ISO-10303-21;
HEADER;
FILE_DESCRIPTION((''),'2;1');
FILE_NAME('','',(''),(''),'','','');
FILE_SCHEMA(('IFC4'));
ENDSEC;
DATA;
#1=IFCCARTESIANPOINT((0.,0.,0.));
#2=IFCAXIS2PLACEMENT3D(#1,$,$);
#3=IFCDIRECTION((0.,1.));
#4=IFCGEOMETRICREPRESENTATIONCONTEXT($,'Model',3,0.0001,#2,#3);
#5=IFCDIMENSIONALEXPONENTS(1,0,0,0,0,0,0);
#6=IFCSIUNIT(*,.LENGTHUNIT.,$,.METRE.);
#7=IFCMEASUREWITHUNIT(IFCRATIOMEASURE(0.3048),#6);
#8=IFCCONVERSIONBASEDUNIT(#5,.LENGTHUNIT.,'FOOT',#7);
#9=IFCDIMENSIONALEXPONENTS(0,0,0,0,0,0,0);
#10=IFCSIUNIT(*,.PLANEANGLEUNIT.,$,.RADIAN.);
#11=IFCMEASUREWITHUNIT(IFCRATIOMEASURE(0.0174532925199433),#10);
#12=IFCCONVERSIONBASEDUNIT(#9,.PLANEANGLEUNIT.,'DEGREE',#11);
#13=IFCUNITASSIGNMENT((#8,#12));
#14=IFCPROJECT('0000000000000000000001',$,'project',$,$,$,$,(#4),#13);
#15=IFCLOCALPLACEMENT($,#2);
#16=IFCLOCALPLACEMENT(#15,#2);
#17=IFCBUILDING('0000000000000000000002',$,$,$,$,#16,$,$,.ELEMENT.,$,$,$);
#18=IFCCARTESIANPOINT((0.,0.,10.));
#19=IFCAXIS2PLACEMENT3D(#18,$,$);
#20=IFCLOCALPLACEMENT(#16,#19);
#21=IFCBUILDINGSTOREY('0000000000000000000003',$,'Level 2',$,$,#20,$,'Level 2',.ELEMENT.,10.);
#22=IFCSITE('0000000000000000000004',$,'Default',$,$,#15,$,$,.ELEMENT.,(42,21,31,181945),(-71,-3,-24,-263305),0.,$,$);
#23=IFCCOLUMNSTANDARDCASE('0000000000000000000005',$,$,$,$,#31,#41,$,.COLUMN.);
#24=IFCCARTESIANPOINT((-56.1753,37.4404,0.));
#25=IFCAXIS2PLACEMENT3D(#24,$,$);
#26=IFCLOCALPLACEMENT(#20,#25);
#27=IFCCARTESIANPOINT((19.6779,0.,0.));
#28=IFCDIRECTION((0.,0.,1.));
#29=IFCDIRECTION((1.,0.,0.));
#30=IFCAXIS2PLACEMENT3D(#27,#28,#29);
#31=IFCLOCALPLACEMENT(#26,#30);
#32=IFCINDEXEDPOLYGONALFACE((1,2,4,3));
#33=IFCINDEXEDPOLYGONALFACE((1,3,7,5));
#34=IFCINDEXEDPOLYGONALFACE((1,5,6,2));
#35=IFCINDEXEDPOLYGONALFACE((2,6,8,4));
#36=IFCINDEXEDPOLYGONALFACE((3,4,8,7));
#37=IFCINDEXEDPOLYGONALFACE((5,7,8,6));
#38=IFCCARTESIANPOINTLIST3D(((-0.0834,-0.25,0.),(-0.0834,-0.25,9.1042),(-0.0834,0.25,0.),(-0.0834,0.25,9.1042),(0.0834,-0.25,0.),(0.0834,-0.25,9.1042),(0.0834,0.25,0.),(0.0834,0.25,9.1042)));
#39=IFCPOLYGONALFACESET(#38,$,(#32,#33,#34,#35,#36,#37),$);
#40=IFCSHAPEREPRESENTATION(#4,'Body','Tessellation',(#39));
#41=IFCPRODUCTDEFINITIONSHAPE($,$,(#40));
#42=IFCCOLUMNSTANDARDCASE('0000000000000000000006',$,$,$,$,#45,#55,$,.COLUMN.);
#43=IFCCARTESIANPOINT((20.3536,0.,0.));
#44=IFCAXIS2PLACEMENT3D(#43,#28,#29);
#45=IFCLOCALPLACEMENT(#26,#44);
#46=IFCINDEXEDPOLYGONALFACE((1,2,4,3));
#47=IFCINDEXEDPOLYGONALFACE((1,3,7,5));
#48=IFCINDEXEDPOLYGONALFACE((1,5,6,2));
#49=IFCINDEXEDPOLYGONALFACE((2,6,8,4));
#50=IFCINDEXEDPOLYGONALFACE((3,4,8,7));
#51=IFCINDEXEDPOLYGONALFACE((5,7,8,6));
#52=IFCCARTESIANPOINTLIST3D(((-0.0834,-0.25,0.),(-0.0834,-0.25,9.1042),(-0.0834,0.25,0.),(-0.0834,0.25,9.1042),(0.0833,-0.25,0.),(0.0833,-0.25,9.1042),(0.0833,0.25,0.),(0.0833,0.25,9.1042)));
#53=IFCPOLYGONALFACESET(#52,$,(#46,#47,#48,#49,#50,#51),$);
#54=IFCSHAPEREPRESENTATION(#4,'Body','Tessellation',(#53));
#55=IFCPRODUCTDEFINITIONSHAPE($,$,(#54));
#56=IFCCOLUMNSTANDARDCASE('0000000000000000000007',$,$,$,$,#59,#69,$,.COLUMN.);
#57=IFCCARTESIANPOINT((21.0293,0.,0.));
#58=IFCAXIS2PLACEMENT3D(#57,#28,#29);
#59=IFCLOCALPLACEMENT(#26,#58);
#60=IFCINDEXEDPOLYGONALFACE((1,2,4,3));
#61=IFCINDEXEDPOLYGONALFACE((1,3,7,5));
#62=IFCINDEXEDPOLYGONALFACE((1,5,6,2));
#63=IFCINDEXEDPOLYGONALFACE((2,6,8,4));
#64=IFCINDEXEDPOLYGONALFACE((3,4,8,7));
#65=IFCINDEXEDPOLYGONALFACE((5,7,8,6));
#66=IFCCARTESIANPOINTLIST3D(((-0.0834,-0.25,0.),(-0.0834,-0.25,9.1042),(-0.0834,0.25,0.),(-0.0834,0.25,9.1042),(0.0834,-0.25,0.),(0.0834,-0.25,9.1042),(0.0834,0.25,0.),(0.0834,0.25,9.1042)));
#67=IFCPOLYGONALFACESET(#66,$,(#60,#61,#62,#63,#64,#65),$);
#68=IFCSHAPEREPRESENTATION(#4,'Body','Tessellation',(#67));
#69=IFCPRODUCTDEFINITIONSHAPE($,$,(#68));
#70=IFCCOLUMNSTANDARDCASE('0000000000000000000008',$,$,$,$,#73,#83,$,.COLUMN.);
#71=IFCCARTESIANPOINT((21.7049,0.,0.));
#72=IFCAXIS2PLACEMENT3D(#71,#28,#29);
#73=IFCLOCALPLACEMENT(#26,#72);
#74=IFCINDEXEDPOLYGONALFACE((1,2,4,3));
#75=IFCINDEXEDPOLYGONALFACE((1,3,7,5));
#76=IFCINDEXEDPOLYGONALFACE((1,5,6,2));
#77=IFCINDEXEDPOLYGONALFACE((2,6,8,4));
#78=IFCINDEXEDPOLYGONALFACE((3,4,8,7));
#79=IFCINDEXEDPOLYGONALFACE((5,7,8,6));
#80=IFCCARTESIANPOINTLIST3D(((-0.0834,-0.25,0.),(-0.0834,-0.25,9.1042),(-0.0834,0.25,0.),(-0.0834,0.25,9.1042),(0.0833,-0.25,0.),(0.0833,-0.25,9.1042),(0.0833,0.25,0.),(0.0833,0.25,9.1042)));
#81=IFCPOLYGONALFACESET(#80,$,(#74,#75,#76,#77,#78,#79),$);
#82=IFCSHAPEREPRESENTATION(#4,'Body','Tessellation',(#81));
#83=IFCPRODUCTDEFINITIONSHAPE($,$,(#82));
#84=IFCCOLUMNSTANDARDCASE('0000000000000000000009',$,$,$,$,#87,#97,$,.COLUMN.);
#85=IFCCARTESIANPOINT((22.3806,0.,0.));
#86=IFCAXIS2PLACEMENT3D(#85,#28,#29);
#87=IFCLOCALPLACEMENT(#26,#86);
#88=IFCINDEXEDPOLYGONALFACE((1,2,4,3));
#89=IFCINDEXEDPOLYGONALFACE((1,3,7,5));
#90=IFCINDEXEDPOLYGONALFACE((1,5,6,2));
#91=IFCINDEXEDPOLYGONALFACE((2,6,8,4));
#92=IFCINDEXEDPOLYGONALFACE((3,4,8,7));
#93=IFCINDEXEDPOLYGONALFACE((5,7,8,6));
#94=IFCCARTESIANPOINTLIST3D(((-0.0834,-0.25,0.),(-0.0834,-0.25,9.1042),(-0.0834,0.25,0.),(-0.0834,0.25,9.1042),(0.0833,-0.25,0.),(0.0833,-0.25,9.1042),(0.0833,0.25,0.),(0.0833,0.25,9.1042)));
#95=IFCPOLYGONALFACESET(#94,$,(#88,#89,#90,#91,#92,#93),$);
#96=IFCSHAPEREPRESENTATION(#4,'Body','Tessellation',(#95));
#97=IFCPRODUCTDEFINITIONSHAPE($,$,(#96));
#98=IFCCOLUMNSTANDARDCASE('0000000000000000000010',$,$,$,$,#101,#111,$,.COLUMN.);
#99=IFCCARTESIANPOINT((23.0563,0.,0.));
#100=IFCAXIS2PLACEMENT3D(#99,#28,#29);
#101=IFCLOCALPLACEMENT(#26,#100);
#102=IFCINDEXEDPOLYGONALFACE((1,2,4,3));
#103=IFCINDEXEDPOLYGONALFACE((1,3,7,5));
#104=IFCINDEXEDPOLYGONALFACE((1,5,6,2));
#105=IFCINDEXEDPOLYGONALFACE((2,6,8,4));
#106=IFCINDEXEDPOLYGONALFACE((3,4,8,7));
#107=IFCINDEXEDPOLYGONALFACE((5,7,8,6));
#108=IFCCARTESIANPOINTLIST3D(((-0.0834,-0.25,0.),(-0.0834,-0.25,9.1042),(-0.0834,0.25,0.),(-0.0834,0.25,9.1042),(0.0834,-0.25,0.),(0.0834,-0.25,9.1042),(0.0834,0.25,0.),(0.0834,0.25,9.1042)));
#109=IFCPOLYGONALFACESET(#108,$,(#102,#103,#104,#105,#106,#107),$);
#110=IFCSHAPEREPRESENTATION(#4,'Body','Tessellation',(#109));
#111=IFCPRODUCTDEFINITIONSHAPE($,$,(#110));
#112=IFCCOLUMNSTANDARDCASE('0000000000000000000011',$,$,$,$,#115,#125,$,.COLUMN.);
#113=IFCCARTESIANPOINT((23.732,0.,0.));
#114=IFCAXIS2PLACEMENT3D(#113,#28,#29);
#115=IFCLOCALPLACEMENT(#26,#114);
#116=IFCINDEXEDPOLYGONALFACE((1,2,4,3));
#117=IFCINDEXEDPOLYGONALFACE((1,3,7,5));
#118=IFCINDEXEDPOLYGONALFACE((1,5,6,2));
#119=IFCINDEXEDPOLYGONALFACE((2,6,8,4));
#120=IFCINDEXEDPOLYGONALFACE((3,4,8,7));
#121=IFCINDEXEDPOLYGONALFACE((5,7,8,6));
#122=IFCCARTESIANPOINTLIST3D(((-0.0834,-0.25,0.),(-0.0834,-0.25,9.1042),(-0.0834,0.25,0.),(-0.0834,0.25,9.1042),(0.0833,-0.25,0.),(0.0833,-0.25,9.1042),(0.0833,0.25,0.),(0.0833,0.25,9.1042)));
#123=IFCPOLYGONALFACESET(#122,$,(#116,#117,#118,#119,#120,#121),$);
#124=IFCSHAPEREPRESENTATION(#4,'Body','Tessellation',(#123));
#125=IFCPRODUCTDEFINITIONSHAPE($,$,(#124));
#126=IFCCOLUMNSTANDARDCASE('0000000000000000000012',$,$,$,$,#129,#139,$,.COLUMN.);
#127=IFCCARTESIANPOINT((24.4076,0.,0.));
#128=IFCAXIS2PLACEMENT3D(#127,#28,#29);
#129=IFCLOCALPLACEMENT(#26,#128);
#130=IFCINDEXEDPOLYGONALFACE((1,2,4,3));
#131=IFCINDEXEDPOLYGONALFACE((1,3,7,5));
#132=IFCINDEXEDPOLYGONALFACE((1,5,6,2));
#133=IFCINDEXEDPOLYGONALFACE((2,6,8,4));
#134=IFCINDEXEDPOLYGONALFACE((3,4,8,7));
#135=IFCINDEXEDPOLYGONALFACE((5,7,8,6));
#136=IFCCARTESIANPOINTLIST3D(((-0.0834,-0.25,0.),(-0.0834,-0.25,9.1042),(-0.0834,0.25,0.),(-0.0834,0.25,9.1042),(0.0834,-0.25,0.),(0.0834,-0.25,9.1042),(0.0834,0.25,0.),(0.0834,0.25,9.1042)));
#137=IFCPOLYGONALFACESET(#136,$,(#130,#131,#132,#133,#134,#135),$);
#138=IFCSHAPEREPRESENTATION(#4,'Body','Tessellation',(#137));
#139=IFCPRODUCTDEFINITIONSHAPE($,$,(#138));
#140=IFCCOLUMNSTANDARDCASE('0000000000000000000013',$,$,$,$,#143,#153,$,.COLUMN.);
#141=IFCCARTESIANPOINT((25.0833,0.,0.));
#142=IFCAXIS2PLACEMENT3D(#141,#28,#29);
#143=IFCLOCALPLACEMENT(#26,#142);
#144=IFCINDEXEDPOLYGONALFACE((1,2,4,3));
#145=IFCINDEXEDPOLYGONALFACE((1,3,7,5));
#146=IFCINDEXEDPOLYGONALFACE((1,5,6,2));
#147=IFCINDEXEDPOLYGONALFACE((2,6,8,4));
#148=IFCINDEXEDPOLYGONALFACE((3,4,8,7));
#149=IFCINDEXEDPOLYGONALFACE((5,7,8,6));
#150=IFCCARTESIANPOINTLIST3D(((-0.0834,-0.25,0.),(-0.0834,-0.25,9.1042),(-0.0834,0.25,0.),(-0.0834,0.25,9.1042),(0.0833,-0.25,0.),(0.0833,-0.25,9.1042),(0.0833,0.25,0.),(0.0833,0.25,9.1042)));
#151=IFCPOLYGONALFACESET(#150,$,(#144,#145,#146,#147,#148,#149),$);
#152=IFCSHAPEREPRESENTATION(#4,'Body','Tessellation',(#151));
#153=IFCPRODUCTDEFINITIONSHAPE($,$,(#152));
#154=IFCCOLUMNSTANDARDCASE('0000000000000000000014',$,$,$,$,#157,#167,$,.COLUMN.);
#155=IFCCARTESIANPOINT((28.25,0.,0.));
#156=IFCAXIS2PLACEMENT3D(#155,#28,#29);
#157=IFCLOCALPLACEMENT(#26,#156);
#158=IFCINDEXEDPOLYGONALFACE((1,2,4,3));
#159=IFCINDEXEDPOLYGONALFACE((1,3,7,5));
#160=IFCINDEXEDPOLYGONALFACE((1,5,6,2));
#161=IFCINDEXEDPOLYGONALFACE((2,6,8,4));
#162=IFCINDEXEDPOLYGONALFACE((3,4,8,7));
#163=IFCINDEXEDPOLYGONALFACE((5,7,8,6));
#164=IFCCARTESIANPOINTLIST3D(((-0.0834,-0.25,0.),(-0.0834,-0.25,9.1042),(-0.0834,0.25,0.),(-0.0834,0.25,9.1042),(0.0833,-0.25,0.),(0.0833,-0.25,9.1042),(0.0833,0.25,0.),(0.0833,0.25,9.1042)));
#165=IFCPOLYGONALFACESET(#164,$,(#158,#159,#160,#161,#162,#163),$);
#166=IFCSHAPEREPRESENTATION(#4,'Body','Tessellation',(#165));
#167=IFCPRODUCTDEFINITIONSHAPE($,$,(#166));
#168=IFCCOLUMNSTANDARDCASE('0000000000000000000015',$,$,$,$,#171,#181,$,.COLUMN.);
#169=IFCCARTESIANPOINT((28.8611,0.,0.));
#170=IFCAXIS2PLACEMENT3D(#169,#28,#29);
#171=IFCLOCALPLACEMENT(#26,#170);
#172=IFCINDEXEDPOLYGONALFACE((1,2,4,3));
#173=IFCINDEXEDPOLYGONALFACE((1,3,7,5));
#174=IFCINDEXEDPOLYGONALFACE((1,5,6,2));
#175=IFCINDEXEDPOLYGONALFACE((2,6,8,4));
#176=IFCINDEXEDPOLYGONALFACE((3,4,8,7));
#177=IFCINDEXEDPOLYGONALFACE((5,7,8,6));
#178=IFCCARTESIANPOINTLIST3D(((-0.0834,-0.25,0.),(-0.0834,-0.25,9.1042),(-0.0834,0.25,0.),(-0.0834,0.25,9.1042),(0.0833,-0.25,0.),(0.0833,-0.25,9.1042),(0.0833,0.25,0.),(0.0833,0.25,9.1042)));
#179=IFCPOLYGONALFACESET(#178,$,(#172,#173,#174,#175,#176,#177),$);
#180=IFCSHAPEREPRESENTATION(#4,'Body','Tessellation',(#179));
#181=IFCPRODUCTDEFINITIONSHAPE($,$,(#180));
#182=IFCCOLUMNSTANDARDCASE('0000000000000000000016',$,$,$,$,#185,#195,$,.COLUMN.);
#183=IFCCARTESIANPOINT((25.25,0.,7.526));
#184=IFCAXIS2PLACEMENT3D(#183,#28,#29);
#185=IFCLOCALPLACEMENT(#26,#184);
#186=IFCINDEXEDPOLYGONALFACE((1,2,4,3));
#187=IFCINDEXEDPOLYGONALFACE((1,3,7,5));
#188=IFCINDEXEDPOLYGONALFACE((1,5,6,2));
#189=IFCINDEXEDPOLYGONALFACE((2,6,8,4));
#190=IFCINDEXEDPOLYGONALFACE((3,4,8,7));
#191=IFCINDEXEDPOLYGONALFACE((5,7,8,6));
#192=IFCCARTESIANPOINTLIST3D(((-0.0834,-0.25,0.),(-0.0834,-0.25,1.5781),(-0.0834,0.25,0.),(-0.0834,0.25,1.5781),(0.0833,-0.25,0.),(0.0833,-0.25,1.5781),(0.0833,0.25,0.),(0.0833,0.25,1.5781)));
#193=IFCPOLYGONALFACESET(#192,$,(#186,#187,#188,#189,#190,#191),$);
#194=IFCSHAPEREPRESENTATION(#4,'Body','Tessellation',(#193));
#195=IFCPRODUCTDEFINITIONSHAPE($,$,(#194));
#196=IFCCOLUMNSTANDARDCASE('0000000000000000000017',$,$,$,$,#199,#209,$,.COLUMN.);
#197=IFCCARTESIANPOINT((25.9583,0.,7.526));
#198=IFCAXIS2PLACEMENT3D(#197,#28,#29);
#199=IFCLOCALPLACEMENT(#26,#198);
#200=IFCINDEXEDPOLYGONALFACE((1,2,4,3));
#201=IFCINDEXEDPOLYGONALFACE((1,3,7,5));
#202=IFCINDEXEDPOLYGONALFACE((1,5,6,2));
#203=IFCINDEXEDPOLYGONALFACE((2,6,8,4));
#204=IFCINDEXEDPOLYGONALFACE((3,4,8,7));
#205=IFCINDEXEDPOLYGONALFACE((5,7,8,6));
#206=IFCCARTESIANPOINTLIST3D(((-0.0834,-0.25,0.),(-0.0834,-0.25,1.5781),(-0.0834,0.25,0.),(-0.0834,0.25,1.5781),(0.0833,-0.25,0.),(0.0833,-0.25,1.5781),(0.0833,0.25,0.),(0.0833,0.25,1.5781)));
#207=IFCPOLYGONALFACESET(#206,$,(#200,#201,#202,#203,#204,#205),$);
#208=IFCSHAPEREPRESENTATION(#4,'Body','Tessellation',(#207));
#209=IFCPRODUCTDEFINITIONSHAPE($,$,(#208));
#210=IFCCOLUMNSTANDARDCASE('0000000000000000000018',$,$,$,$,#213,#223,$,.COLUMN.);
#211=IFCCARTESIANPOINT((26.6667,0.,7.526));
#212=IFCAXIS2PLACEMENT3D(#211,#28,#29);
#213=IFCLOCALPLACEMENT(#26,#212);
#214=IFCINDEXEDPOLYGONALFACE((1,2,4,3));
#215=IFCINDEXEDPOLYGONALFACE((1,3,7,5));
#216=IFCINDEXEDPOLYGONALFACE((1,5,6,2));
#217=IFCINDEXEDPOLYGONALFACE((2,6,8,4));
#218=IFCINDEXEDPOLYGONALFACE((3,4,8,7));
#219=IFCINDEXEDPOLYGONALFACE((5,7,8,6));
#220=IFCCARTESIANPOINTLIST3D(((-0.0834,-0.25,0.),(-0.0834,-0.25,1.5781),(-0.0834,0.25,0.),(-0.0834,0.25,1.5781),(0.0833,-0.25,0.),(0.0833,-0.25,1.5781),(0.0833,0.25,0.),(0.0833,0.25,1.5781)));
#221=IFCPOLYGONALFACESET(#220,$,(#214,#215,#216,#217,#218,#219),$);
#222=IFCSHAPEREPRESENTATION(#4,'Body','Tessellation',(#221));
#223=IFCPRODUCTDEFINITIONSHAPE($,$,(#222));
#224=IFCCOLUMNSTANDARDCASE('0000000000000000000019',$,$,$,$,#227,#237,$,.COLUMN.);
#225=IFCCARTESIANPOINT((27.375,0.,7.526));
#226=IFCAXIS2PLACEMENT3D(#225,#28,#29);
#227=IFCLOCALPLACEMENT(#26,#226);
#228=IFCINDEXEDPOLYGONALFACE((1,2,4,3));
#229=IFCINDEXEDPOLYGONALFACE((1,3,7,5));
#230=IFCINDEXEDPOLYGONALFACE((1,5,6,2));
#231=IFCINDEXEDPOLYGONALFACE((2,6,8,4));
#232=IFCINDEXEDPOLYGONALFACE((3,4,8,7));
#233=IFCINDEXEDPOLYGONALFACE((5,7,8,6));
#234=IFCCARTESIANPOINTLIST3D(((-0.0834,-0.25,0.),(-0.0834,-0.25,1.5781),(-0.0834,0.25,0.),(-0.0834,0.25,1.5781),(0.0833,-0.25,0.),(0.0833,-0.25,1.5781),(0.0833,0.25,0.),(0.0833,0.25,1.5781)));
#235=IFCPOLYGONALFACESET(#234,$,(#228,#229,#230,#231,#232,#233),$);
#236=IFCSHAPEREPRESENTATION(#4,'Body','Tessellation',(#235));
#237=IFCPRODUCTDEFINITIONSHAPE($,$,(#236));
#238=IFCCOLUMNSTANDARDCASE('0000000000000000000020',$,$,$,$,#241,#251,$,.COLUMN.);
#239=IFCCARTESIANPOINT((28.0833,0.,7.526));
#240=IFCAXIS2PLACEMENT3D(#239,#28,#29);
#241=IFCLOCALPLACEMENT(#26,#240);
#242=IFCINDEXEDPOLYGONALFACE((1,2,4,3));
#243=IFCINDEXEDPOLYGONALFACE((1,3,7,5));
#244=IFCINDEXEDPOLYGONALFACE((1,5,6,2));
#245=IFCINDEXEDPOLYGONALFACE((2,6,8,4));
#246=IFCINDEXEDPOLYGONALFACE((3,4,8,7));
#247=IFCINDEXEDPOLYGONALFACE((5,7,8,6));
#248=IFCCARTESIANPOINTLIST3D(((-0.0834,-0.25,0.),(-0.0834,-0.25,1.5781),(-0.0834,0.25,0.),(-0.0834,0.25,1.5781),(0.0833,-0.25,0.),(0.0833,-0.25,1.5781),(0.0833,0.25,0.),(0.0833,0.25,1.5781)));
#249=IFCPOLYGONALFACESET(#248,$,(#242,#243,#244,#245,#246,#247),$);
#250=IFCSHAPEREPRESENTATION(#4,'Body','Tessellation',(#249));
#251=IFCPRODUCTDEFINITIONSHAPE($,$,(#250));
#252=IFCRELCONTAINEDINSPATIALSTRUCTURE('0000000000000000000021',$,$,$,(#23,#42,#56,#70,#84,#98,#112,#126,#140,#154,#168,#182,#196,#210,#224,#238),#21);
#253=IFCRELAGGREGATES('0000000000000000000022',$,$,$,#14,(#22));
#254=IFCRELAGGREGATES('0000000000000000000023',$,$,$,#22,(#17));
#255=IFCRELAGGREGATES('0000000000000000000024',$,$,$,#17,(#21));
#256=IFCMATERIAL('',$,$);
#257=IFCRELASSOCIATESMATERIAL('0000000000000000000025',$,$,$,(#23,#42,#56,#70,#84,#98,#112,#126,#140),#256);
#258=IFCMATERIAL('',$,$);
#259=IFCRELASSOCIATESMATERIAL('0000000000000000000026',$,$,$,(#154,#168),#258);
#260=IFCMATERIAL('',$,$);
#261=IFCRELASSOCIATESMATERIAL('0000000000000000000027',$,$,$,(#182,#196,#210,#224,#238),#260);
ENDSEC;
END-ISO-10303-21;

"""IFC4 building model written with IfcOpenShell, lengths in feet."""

from ifc_helpers import new_model, entity, si_unit, converted_unit, direction, frame, origin, place, context, project, spatial, rectangle, extrude, material, element, save


model = new_model("IFC4")

# Units and contexts
model_context = context("Model", 3, precision=0.0001, world=origin(), true_north=direction((0.0, 1.0)))
ifc_project = project(units=[converted_unit("LENGTHUNIT", "FOOT", entity("IfcRatioMeasure", 0.3048), si_unit("LENGTHUNIT", "METRE"), dimensions=[1, 0, 0, 0, 0, 0, 0]), converted_unit("PLANEANGLEUNIT", "DEGREE", entity("IfcRatioMeasure", 0.0174532925199433), si_unit("PLANEANGLEUNIT", "RADIAN"), dimensions=[0, 0, 0, 0, 0, 0, 0])], contexts=[model_context])

# Site, building, storey
site_placement = place(None, origin())
site = spatial("IfcSite", under=ifc_project, at=site_placement, Name="Default", CompositionType="ELEMENT", RefLatitude=(42, 21, 31, 181945), RefLongitude=(-71, -3, -24, -263305), RefElevation=0.0)
building_placement = place(site_placement, origin())
building = spatial("IfcBuilding", under=site, at=building_placement, CompositionType="ELEMENT")
storey_placement = place(building_placement, frame((0.0, 0.0, 10.0)))
storey = spatial("IfcBuildingStorey", under=building, at=storey_placement, Name="Level 2", LongName="Level 2", CompositionType="ELEMENT", Elevation=10.0)

# Columns
ifc_material_1 = material(Name="")
placement = place(storey_placement, frame((-56.1753, 37.4404, 0.0)))
for number, where, z_axis, x_axis in (
    (1, (19.6779, 0.0, 0.0), (0.0, 0.0, 1.0), (1.0, 0.0, 0.0)),
    (2, (20.3536, 0.0, 0.0), (0.0, 0.0, 1.0), (1.0, 0.0, 0.0)),
    (3, (21.0293, 0.0, 0.0), (0.0, 0.0, 1.0), (1.0, 0.0, 0.0)),
    (4, (21.7049, 0.0, 0.0), (0.0, 0.0, 1.0), (1.0, 0.0, 0.0)),
    (5, (22.3806, 0.0, 0.0), (0.0, 0.0, 1.0), (1.0, 0.0, 0.0)),
    (6, (23.0563, 0.0, 0.0), (0.0, 0.0, 1.0), (1.0, 0.0, 0.0)),
    (7, (23.732, 0.0, 0.0), (0.0, 0.0, 1.0), (1.0, 0.0, 0.0)),
    (8, (24.4076, 0.0, 0.0), (0.0, 0.0, 1.0), (1.0, 0.0, 0.0)),
    (9, (25.0833, 0.0, 0.0), (0.0, 0.0, 1.0), (1.0, 0.0, 0.0)),
):
    element("IfcColumnStandardCase", number, at=place(placement, frame(where, z_axis=z_axis, x_axis=x_axis)), inside=storey, material=ifc_material_1, PredefinedType="COLUMN", context=model_context, shape_type="SweptSolid", body=[
        extrude(rectangle(XDim=0.1667, YDim=0.5), origin(), (0.0, 0.0, 1.0), 9.1042),
    ])
ifc_material_2 = material(Name="")
for number, where, z_axis, x_axis in (
    (10, (28.25, 0.0, 0.0), (0.0, 0.0, 1.0), (1.0, 0.0, 0.0)),
    (11, (28.8611, 0.0, 0.0), (0.0, 0.0, 1.0), (1.0, 0.0, 0.0)),
):
    element("IfcColumnStandardCase", number, at=place(placement, frame(where, z_axis=z_axis, x_axis=x_axis)), inside=storey, material=ifc_material_2, PredefinedType="COLUMN", context=model_context, shape_type="SweptSolid", body=[
        extrude(rectangle(XDim=0.1667, YDim=0.5), origin(), (0.0, 0.0, 1.0), 9.1042),
    ])
ifc_material_3 = material(Name="")
for number, where, z_axis, x_axis in (
    (12, (25.25, 0.0, 7.526), (0.0, 0.0, 1.0), (1.0, 0.0, 0.0)),
    (13, (25.9583, 0.0, 7.526), (0.0, 0.0, 1.0), (1.0, 0.0, 0.0)),
    (14, (26.6667, 0.0, 7.526), (0.0, 0.0, 1.0), (1.0, 0.0, 0.0)),
    (15, (27.375, 0.0, 7.526), (0.0, 0.0, 1.0), (1.0, 0.0, 0.0)),
    (16, (28.0833, 0.0, 7.526), (0.0, 0.0, 1.0), (1.0, 0.0, 0.0)),
):
    element("IfcColumnStandardCase", number, at=place(placement, frame(where, z_axis=z_axis, x_axis=x_axis)), inside=storey, material=ifc_material_3, PredefinedType="COLUMN", context=model_context, shape_type="SweptSolid", body=[
        extrude(rectangle(XDim=0.1667, YDim=0.5), origin(), (0.0, 0.0, 1.0), 1.5781),
    ])

save(model, "model.ifc")
